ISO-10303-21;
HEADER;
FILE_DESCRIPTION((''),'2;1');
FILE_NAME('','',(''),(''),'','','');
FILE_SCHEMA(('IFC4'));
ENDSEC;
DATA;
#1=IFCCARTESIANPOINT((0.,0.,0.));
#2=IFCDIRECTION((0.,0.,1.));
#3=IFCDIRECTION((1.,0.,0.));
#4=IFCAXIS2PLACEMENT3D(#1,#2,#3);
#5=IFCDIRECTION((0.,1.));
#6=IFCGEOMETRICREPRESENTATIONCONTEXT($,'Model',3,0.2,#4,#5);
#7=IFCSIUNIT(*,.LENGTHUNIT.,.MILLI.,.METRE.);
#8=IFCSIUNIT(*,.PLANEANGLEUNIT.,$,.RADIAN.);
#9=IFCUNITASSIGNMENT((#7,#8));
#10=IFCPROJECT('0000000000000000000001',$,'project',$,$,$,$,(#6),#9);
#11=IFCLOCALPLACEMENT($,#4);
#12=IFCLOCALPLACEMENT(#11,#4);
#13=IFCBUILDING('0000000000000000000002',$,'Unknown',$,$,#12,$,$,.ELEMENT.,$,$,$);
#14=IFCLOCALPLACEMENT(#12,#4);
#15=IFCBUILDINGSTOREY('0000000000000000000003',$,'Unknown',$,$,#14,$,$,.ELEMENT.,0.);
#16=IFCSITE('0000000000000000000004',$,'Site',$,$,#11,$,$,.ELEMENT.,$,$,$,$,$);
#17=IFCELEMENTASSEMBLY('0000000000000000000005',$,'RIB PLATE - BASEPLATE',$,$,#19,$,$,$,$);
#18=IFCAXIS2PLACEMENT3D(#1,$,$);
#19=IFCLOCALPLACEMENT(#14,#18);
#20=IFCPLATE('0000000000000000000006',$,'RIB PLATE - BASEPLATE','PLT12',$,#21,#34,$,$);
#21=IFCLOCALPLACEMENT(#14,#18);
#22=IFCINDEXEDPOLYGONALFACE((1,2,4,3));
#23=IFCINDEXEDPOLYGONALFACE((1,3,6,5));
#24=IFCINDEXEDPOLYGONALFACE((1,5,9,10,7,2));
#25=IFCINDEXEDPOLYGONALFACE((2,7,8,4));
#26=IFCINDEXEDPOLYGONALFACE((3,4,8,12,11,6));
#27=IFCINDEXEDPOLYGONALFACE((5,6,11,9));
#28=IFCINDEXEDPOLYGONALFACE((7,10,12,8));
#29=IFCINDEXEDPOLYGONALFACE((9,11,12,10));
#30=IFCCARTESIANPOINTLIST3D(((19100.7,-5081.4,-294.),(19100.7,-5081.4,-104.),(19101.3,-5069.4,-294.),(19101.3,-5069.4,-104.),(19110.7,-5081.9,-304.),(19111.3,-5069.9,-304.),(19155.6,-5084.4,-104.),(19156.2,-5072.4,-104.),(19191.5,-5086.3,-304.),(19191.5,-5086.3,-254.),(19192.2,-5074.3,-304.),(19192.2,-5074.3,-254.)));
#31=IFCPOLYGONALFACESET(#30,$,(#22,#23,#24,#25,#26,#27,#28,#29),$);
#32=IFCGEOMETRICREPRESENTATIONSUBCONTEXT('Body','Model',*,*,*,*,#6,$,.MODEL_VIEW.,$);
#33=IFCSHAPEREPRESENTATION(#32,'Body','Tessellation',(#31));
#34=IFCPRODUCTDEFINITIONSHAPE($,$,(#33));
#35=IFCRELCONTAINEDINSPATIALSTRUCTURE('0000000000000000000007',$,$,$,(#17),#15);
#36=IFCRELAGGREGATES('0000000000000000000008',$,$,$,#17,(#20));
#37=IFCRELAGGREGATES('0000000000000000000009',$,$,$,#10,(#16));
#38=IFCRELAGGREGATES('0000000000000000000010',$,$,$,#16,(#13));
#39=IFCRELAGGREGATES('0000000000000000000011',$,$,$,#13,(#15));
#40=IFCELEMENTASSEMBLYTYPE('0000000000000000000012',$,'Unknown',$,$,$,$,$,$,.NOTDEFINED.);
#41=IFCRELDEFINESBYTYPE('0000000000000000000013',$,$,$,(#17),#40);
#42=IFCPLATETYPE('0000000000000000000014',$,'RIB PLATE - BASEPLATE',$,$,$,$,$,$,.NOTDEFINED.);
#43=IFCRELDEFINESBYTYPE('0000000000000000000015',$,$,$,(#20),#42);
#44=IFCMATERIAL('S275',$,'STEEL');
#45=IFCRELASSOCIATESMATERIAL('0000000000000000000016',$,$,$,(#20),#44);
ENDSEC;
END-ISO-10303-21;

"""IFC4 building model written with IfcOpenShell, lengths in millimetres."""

from ifc_helpers import new_model, si_unit, direction, frame, origin_with_axes, place, context, subcontext, project, spatial, line, indexed_curve, outline, extrude, material, material_profile, profile_set, profile_usage, type_object, element, aggregate, save


model = new_model("IFC4")

# Units and contexts
model_context = context("Model", 3, precision=0.2, world=origin_with_axes(), true_north=direction((0.0, 1.0)))
body_context = subcontext(model_context, "Body", "Model", "MODEL_VIEW")
ifc_project = project(units=[si_unit("LENGTHUNIT", "METRE", prefix="MILLI"), si_unit("PLANEANGLEUNIT", "RADIAN")], contexts=[model_context])

# Site, building, storey
site_placement = place(None, origin_with_axes())
site = spatial("IfcSite", under=ifc_project, at=site_placement, Name="Site", CompositionType="ELEMENT")
building_placement = place(site_placement, origin_with_axes())
building = spatial("IfcBuilding", under=site, at=building_placement, Name="Unknown", CompositionType="ELEMENT")
storey_placement = place(building_placement, origin_with_axes())
storey = spatial("IfcBuildingStorey", under=building, at=storey_placement, Name="Unknown", CompositionType="ELEMENT", Elevation=0.0)

# Shared definitions
element_assembly_type = type_object("IfcElementAssemblyType", Name="Unknown", PredefinedType="NOTDEFINED")
ifc_material_1 = material(Name="S275", Category="STEEL")

# Element assembly, plate
assembly_1_placement = place(storey_placement, frame((19191.9, -5080.3, -304.0), z_axis=(0.054382, 0.99852, 0.0), x_axis=(-0.99852, 0.054382, 0.0)))
assembly_1 = element("IfcElementAssembly", 1, at=assembly_1_placement, inside=storey, type_object=element_assembly_type, Name="RIB PLATE - BASEPLATE")
ifc_material_profile_1 = material_profile(ifc_material_1, outline(indexed_curve([(0.0, 0.0), (81.0, 0.0), (91.0, 10.0), (91.0, 200.0), (36.0, 200.0), (0.0, 50.0)], segments=[line(1, 2, 3, 4, 5, 6, 1)])), Name="PLT12")
ifc_profile_set_1 = profile_set([ifc_material_profile_1])
ifc_profile_usage_1 = profile_usage(ifc_profile_set_1, cardinal=5)
plate_type_1 = type_object("IfcPlateType", Name="RIB PLATE - BASEPLATE", PredefinedType="NOTDEFINED")
plate_1_placement = place(assembly_1_placement, origin_with_axes())
plate_1 = element("IfcPlate", 2, at=plate_1_placement, type_object=plate_type_1, material=ifc_profile_usage_1, Name="RIB PLATE - BASEPLATE", Description="PLT12", context=body_context, shape_type="SolidModel", body=[
    extrude(outline(indexed_curve([(0.0, 0.0), (81.0, 0.0), (91.0, 10.0), (91.0, 200.0), (36.0, 200.0), (0.0, 50.0)], segments=[line(1, 2, 3, 4, 5, 6, 1)])), frame((0.0, 0.0, 6.0), z_axis=(0.0, 0.0, 1.0), x_axis=(1.0, 0.0, 0.0)), (0.0, 0.0, -1.0), 12.0),
])
aggregate(assembly_1, [plate_1])

save(model, "model.ifc")
